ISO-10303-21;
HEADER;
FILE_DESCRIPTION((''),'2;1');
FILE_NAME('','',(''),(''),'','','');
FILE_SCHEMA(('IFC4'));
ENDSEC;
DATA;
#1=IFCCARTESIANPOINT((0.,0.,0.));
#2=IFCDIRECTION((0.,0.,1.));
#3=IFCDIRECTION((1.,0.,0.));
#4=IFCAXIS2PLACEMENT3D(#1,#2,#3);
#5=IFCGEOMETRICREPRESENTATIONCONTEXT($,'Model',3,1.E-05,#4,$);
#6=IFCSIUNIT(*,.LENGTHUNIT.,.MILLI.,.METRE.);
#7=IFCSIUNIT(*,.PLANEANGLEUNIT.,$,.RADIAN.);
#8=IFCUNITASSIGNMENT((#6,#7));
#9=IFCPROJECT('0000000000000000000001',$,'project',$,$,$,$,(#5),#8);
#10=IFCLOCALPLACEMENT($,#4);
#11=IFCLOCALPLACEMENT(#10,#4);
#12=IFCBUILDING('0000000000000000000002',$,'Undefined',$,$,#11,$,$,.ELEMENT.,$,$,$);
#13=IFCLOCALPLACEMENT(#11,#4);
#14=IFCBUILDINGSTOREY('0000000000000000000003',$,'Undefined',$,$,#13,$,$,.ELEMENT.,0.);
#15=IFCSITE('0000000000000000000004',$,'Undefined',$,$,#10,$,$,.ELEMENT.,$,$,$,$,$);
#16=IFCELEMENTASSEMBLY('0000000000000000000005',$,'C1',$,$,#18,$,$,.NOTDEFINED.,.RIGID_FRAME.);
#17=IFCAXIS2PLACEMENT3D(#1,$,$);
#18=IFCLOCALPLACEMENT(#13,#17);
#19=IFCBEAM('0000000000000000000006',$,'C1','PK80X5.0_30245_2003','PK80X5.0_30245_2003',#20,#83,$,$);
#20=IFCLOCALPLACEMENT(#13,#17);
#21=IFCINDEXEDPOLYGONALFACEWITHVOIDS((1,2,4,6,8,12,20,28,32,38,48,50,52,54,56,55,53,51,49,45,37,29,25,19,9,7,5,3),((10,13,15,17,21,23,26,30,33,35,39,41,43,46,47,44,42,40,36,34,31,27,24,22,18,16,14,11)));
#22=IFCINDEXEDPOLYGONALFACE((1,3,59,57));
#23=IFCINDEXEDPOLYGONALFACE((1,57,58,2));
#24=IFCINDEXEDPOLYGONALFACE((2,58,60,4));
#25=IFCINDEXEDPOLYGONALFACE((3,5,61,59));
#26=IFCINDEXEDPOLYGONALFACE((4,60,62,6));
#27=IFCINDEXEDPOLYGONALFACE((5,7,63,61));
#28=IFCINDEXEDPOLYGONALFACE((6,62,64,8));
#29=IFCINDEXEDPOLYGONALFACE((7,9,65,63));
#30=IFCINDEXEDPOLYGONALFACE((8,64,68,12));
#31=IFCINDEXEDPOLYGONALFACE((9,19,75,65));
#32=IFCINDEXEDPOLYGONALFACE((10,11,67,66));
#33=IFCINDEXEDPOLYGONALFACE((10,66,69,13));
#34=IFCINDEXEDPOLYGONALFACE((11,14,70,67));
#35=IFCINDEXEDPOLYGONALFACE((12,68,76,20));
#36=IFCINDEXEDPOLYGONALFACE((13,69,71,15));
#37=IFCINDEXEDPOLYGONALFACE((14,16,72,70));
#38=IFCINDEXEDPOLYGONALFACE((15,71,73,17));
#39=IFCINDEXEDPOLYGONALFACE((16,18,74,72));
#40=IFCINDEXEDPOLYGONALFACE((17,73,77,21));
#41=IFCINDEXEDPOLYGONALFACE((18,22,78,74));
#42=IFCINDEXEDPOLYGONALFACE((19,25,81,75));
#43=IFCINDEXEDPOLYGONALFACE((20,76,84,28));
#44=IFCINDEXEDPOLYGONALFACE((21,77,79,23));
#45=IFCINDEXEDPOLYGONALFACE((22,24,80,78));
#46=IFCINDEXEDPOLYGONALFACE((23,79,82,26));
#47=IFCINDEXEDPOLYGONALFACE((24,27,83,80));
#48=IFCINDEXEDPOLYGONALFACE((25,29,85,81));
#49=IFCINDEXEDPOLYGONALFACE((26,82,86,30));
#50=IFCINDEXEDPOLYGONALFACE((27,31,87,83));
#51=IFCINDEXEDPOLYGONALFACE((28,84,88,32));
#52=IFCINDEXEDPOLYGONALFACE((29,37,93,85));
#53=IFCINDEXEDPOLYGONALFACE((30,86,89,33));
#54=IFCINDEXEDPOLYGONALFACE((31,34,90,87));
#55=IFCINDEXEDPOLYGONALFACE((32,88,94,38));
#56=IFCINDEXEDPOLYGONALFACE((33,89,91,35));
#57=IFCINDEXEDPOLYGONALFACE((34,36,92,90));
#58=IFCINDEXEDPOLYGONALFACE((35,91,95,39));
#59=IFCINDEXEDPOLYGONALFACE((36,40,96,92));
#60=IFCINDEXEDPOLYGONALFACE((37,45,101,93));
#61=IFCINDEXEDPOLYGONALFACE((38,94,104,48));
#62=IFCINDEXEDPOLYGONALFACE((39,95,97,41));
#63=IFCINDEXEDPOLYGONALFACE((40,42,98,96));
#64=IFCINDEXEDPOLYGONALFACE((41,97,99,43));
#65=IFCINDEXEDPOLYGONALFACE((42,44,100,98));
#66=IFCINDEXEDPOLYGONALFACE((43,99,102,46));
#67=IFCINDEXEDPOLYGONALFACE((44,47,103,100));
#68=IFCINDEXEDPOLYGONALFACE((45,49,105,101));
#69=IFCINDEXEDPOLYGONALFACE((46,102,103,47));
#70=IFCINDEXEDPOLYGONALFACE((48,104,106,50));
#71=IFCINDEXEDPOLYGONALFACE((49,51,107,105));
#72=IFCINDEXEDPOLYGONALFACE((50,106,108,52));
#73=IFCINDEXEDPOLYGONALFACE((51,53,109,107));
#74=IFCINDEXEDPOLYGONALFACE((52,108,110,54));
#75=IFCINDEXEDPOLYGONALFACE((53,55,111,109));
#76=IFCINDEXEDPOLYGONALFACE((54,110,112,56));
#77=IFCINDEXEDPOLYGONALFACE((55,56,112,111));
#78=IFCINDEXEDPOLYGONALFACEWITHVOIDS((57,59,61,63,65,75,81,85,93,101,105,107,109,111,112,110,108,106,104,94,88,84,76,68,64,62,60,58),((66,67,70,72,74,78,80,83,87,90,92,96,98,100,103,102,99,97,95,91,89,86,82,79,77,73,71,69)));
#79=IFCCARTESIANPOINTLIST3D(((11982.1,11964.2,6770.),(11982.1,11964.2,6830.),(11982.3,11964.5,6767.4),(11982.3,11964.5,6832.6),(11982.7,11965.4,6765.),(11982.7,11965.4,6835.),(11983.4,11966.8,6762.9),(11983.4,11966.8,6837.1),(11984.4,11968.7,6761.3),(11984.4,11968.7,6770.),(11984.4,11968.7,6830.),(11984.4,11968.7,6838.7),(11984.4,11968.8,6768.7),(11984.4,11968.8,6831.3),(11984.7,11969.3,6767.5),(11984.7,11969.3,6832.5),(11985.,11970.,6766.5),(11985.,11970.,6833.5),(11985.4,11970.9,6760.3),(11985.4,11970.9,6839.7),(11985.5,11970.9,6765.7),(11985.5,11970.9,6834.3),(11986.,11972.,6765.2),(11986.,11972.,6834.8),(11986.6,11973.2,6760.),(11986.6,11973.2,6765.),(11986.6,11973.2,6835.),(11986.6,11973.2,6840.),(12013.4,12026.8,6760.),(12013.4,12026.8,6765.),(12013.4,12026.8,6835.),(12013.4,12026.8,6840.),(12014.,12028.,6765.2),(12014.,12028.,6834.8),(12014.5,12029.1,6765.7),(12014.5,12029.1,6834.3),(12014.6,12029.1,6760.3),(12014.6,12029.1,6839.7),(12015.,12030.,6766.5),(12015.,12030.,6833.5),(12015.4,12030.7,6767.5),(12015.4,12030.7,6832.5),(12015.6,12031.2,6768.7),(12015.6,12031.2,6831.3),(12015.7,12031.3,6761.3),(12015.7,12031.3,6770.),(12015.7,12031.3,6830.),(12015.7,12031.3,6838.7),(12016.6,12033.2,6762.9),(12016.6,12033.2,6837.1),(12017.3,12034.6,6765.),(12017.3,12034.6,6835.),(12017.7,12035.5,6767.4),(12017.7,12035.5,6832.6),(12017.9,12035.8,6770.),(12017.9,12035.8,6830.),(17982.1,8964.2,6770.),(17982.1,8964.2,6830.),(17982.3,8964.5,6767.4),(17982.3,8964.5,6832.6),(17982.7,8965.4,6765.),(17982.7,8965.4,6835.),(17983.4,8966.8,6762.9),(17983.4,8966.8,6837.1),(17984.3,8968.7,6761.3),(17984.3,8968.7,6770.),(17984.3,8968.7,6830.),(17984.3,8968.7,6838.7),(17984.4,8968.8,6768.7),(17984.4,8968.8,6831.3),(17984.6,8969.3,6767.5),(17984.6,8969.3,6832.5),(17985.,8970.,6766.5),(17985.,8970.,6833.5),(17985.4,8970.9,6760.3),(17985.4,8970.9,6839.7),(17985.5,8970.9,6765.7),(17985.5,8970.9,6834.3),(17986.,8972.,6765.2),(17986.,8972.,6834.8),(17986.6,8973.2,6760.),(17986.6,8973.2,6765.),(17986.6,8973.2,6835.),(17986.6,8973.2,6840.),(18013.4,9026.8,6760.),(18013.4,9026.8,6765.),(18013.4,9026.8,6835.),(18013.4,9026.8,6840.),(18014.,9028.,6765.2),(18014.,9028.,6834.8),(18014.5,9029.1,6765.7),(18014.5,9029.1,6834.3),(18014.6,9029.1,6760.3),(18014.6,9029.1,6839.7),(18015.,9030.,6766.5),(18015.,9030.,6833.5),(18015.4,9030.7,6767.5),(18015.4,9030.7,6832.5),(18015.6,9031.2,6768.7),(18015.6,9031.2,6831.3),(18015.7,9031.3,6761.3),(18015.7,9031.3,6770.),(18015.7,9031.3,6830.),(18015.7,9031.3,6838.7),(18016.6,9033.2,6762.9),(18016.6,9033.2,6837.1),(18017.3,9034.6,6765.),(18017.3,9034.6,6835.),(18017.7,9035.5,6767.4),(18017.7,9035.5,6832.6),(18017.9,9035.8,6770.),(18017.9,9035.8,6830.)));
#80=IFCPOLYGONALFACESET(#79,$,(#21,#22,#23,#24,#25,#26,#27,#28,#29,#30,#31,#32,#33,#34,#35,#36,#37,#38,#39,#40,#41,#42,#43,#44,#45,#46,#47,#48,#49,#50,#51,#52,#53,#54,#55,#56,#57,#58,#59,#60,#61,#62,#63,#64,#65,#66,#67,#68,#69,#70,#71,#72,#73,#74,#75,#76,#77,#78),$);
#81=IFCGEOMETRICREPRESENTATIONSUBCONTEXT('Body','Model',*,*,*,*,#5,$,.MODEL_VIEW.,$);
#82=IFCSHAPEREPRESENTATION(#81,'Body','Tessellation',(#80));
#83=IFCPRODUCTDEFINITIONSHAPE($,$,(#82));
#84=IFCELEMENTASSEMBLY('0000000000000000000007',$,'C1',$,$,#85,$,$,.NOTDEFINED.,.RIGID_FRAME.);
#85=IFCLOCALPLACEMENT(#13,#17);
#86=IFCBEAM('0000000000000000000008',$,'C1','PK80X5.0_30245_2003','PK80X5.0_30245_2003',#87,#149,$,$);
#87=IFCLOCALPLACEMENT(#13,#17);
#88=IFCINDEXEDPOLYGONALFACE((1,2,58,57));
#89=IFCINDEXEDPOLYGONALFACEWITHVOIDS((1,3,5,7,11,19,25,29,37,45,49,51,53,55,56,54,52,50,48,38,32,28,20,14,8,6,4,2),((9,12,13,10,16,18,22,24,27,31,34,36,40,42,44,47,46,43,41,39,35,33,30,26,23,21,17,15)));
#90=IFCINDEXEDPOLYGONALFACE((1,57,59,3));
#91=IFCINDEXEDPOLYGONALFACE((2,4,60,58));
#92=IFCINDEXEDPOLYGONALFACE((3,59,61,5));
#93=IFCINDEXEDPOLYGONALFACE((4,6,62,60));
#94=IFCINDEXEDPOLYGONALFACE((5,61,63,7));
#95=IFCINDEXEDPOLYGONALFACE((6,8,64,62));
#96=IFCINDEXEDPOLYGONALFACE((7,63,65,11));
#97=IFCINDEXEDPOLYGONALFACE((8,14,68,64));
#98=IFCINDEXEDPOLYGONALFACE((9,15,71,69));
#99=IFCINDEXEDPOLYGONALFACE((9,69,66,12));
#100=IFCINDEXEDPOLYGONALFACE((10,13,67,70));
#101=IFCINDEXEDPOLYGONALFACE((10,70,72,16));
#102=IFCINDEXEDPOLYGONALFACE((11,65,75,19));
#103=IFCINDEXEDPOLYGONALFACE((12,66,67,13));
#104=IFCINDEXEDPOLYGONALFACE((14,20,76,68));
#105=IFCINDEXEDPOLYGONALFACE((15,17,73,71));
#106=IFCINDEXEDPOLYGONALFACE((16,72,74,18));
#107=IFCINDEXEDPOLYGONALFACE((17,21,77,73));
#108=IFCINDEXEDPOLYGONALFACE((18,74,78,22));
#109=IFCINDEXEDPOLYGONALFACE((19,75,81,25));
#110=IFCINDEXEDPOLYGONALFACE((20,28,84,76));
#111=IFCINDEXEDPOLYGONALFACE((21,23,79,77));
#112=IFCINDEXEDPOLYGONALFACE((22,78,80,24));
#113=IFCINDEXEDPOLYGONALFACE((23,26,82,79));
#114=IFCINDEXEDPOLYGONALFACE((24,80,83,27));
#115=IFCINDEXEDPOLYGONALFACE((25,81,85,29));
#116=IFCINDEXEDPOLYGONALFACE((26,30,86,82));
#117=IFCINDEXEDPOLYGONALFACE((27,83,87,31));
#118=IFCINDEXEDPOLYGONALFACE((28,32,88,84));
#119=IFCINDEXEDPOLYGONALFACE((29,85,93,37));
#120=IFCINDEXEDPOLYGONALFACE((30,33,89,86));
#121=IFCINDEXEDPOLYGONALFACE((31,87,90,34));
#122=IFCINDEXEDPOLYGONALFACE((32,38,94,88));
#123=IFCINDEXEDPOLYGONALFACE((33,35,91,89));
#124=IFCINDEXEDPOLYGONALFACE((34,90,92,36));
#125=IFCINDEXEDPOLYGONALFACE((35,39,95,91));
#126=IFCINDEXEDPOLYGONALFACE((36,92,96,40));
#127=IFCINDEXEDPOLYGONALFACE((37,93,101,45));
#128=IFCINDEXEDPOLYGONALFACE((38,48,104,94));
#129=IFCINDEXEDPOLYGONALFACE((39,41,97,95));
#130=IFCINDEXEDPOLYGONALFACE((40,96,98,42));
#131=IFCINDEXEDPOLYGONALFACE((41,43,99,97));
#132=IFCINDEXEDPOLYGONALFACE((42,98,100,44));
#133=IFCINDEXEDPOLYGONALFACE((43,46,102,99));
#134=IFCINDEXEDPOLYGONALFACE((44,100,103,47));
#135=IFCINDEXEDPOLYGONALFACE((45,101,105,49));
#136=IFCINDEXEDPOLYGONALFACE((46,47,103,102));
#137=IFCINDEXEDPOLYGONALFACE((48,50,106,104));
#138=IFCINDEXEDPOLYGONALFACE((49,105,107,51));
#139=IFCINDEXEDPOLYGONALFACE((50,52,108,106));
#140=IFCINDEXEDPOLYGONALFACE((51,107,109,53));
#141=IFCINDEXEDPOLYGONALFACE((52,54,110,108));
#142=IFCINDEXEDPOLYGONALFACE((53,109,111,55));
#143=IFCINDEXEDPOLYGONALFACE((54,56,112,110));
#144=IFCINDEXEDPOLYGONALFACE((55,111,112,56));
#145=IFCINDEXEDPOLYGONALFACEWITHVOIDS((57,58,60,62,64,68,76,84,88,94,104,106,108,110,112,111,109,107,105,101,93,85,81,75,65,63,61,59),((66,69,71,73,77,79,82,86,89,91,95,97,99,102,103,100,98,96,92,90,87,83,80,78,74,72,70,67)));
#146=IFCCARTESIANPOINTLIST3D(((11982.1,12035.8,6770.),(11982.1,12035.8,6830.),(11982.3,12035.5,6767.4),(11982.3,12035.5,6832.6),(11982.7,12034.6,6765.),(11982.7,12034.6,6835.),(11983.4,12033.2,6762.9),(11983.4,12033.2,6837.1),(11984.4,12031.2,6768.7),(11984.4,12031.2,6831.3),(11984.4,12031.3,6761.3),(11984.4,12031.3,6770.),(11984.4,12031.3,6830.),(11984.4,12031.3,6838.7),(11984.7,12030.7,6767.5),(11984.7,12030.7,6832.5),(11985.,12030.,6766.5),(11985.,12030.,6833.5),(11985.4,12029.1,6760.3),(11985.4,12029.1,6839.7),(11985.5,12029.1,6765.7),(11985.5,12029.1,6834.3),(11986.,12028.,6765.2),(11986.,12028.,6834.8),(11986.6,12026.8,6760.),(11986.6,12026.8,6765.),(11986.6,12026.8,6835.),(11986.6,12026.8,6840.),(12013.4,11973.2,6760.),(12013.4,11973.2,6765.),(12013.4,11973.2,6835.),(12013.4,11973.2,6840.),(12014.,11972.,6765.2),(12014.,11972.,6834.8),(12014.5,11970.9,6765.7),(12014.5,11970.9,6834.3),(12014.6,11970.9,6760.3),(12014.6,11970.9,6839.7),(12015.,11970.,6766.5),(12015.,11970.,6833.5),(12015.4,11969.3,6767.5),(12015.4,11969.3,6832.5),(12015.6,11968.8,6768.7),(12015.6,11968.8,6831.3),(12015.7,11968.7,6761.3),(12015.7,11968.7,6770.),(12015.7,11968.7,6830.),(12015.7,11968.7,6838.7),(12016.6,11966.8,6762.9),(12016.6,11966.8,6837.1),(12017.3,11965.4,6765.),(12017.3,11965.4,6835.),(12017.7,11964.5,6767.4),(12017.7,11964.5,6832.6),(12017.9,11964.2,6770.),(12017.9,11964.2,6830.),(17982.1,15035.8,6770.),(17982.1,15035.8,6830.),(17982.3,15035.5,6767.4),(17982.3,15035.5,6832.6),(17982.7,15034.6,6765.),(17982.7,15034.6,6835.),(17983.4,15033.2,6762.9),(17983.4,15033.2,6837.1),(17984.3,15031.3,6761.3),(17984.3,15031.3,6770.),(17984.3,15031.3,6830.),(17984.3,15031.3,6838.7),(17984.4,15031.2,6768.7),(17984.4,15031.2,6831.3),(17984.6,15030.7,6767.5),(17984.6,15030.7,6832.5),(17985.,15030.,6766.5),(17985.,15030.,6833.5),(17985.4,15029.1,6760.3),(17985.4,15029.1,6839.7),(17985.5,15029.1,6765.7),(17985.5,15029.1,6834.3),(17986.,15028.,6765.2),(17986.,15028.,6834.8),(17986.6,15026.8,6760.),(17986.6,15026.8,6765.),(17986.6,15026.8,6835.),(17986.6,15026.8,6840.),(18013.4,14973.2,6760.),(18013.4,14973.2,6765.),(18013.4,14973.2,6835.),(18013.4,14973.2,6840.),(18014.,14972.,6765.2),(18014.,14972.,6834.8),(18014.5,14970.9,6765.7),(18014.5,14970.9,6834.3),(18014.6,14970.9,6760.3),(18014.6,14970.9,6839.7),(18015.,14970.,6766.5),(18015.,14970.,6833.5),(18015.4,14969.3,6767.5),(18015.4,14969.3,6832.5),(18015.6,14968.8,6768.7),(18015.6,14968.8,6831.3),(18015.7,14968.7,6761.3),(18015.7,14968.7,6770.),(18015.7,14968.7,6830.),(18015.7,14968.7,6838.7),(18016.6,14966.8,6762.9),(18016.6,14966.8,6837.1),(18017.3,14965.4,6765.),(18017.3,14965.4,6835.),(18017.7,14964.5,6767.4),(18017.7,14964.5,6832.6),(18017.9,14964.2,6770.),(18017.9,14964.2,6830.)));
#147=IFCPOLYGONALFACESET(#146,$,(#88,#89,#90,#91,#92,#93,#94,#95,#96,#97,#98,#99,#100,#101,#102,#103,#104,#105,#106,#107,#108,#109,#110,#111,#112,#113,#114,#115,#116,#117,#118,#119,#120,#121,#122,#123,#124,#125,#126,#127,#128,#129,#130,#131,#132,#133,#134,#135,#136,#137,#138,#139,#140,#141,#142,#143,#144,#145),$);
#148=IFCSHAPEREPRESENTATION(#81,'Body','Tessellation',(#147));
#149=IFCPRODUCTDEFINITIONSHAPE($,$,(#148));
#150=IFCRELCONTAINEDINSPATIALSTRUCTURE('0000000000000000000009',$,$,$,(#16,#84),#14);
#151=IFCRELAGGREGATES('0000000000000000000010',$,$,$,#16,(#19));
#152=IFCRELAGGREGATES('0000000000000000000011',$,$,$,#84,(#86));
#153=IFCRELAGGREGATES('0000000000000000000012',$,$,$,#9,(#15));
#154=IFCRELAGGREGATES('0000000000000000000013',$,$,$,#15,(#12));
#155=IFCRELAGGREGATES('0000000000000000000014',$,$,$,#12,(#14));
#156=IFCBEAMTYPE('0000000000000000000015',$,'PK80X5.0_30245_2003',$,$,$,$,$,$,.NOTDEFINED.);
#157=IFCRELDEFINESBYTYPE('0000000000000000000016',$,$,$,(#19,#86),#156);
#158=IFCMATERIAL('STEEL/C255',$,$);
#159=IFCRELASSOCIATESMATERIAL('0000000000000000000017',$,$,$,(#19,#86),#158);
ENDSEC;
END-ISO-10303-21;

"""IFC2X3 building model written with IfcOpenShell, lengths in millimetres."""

from ifc_helpers import new_model, si_unit, frame, origin_with_axes, origin_2d_with_axis, place, context, subcontext, project, spatial, hollow_rectangle, extrude, material, type_object, element, aggregate, save


model = new_model("IFC2X3")

# Units and contexts
model_context = context("Model", 3, precision=1e-05, world=origin_with_axes())
body_context = subcontext(model_context, "Body", "Model", "MODEL_VIEW")
ifc_project = project(units=[si_unit("LENGTHUNIT", "METRE", prefix="MILLI"), si_unit("PLANEANGLEUNIT", "RADIAN")], contexts=[model_context])

# Site, building, storey
site_placement = place(None, origin_with_axes())
site = spatial("IfcSite", under=ifc_project, at=site_placement, Name="Undefined", CompositionType="ELEMENT")
building_placement = place(site_placement, origin_with_axes())
building = spatial("IfcBuilding", under=site, at=building_placement, Name="Undefined", CompositionType="ELEMENT")
storey_placement = place(building_placement, origin_with_axes())
storey = spatial("IfcBuildingStorey", under=building, at=storey_placement, Name="Undefined", CompositionType="ELEMENT", Elevation=0.0)

# Element assemblies, beams
ifc_material_1 = material(Name="STEEL/C255")
beam_type_1 = type_object("IfcBeamType", Name="PK80X5.0_30245_2003", PredefinedType="NOTDEFINED")
assembly_1_placement = place(storey_placement, origin_with_axes())
assembly_1 = element("IfcElementAssembly", 1, at=assembly_1_placement, inside=storey, Name="C1", AssemblyPlace="NOTDEFINED", PredefinedType="RIGID_FRAME")
beam_1_placement = place(assembly_1_placement, frame((12000.0, 12000.0, 6800.0), z_axis=(0.0, 0.0, -1.0), x_axis=(0.894427, -0.447214, 0.0)))
beam_1 = element("IfcBeam", 2, at=beam_1_placement, type_object=beam_type_1, material=ifc_material_1, Name="C1", Description="PK80X5.0_30245_2003", ObjectType="PK80X5.0_30245_2003", context=body_context, shape_type="SweptSolid", body=[
    extrude(hollow_rectangle(XDim=80.0, YDim=80.0, WallThickness=5.0, InnerFilletRadius=5.0, OuterFilletRadius=10.0, at=origin_2d_with_axis()), frame((6708.2, 0.0, 0.0), z_axis=(-1.0, 0.0, 0.0), x_axis=(0.0, -1.0, 0.0)), (0.0, 0.0, 1.0), 6708.2),
])
aggregate(assembly_1, [beam_1])
assembly_2_placement = place(storey_placement, origin_with_axes())
assembly_2 = element("IfcElementAssembly", 3, at=assembly_2_placement, inside=storey, Name="C1", AssemblyPlace="NOTDEFINED", PredefinedType="RIGID_FRAME")
beam_2_placement = place(assembly_2_placement, frame((12000.0, 12000.0, 6800.0), z_axis=(0.0, 0.0, -1.0), x_axis=(0.894427, 0.447214, 0.0)))
beam_2 = element("IfcBeam", 4, at=beam_2_placement, type_object=beam_type_1, material=ifc_material_1, Name="C1", Description="PK80X5.0_30245_2003", ObjectType="PK80X5.0_30245_2003", context=body_context, shape_type="SweptSolid", body=[
    extrude(hollow_rectangle(XDim=80.0, YDim=80.0, WallThickness=5.0, InnerFilletRadius=5.0, OuterFilletRadius=10.0, at=origin_2d_with_axis()), frame((6708.2, 0.0, 0.0), z_axis=(-1.0, 0.0, 0.0), x_axis=(0.0, -1.0, 0.0)), (0.0, 0.0, 1.0), 6708.2),
])
aggregate(assembly_2, [beam_2])

save(model, "model.ifc")
